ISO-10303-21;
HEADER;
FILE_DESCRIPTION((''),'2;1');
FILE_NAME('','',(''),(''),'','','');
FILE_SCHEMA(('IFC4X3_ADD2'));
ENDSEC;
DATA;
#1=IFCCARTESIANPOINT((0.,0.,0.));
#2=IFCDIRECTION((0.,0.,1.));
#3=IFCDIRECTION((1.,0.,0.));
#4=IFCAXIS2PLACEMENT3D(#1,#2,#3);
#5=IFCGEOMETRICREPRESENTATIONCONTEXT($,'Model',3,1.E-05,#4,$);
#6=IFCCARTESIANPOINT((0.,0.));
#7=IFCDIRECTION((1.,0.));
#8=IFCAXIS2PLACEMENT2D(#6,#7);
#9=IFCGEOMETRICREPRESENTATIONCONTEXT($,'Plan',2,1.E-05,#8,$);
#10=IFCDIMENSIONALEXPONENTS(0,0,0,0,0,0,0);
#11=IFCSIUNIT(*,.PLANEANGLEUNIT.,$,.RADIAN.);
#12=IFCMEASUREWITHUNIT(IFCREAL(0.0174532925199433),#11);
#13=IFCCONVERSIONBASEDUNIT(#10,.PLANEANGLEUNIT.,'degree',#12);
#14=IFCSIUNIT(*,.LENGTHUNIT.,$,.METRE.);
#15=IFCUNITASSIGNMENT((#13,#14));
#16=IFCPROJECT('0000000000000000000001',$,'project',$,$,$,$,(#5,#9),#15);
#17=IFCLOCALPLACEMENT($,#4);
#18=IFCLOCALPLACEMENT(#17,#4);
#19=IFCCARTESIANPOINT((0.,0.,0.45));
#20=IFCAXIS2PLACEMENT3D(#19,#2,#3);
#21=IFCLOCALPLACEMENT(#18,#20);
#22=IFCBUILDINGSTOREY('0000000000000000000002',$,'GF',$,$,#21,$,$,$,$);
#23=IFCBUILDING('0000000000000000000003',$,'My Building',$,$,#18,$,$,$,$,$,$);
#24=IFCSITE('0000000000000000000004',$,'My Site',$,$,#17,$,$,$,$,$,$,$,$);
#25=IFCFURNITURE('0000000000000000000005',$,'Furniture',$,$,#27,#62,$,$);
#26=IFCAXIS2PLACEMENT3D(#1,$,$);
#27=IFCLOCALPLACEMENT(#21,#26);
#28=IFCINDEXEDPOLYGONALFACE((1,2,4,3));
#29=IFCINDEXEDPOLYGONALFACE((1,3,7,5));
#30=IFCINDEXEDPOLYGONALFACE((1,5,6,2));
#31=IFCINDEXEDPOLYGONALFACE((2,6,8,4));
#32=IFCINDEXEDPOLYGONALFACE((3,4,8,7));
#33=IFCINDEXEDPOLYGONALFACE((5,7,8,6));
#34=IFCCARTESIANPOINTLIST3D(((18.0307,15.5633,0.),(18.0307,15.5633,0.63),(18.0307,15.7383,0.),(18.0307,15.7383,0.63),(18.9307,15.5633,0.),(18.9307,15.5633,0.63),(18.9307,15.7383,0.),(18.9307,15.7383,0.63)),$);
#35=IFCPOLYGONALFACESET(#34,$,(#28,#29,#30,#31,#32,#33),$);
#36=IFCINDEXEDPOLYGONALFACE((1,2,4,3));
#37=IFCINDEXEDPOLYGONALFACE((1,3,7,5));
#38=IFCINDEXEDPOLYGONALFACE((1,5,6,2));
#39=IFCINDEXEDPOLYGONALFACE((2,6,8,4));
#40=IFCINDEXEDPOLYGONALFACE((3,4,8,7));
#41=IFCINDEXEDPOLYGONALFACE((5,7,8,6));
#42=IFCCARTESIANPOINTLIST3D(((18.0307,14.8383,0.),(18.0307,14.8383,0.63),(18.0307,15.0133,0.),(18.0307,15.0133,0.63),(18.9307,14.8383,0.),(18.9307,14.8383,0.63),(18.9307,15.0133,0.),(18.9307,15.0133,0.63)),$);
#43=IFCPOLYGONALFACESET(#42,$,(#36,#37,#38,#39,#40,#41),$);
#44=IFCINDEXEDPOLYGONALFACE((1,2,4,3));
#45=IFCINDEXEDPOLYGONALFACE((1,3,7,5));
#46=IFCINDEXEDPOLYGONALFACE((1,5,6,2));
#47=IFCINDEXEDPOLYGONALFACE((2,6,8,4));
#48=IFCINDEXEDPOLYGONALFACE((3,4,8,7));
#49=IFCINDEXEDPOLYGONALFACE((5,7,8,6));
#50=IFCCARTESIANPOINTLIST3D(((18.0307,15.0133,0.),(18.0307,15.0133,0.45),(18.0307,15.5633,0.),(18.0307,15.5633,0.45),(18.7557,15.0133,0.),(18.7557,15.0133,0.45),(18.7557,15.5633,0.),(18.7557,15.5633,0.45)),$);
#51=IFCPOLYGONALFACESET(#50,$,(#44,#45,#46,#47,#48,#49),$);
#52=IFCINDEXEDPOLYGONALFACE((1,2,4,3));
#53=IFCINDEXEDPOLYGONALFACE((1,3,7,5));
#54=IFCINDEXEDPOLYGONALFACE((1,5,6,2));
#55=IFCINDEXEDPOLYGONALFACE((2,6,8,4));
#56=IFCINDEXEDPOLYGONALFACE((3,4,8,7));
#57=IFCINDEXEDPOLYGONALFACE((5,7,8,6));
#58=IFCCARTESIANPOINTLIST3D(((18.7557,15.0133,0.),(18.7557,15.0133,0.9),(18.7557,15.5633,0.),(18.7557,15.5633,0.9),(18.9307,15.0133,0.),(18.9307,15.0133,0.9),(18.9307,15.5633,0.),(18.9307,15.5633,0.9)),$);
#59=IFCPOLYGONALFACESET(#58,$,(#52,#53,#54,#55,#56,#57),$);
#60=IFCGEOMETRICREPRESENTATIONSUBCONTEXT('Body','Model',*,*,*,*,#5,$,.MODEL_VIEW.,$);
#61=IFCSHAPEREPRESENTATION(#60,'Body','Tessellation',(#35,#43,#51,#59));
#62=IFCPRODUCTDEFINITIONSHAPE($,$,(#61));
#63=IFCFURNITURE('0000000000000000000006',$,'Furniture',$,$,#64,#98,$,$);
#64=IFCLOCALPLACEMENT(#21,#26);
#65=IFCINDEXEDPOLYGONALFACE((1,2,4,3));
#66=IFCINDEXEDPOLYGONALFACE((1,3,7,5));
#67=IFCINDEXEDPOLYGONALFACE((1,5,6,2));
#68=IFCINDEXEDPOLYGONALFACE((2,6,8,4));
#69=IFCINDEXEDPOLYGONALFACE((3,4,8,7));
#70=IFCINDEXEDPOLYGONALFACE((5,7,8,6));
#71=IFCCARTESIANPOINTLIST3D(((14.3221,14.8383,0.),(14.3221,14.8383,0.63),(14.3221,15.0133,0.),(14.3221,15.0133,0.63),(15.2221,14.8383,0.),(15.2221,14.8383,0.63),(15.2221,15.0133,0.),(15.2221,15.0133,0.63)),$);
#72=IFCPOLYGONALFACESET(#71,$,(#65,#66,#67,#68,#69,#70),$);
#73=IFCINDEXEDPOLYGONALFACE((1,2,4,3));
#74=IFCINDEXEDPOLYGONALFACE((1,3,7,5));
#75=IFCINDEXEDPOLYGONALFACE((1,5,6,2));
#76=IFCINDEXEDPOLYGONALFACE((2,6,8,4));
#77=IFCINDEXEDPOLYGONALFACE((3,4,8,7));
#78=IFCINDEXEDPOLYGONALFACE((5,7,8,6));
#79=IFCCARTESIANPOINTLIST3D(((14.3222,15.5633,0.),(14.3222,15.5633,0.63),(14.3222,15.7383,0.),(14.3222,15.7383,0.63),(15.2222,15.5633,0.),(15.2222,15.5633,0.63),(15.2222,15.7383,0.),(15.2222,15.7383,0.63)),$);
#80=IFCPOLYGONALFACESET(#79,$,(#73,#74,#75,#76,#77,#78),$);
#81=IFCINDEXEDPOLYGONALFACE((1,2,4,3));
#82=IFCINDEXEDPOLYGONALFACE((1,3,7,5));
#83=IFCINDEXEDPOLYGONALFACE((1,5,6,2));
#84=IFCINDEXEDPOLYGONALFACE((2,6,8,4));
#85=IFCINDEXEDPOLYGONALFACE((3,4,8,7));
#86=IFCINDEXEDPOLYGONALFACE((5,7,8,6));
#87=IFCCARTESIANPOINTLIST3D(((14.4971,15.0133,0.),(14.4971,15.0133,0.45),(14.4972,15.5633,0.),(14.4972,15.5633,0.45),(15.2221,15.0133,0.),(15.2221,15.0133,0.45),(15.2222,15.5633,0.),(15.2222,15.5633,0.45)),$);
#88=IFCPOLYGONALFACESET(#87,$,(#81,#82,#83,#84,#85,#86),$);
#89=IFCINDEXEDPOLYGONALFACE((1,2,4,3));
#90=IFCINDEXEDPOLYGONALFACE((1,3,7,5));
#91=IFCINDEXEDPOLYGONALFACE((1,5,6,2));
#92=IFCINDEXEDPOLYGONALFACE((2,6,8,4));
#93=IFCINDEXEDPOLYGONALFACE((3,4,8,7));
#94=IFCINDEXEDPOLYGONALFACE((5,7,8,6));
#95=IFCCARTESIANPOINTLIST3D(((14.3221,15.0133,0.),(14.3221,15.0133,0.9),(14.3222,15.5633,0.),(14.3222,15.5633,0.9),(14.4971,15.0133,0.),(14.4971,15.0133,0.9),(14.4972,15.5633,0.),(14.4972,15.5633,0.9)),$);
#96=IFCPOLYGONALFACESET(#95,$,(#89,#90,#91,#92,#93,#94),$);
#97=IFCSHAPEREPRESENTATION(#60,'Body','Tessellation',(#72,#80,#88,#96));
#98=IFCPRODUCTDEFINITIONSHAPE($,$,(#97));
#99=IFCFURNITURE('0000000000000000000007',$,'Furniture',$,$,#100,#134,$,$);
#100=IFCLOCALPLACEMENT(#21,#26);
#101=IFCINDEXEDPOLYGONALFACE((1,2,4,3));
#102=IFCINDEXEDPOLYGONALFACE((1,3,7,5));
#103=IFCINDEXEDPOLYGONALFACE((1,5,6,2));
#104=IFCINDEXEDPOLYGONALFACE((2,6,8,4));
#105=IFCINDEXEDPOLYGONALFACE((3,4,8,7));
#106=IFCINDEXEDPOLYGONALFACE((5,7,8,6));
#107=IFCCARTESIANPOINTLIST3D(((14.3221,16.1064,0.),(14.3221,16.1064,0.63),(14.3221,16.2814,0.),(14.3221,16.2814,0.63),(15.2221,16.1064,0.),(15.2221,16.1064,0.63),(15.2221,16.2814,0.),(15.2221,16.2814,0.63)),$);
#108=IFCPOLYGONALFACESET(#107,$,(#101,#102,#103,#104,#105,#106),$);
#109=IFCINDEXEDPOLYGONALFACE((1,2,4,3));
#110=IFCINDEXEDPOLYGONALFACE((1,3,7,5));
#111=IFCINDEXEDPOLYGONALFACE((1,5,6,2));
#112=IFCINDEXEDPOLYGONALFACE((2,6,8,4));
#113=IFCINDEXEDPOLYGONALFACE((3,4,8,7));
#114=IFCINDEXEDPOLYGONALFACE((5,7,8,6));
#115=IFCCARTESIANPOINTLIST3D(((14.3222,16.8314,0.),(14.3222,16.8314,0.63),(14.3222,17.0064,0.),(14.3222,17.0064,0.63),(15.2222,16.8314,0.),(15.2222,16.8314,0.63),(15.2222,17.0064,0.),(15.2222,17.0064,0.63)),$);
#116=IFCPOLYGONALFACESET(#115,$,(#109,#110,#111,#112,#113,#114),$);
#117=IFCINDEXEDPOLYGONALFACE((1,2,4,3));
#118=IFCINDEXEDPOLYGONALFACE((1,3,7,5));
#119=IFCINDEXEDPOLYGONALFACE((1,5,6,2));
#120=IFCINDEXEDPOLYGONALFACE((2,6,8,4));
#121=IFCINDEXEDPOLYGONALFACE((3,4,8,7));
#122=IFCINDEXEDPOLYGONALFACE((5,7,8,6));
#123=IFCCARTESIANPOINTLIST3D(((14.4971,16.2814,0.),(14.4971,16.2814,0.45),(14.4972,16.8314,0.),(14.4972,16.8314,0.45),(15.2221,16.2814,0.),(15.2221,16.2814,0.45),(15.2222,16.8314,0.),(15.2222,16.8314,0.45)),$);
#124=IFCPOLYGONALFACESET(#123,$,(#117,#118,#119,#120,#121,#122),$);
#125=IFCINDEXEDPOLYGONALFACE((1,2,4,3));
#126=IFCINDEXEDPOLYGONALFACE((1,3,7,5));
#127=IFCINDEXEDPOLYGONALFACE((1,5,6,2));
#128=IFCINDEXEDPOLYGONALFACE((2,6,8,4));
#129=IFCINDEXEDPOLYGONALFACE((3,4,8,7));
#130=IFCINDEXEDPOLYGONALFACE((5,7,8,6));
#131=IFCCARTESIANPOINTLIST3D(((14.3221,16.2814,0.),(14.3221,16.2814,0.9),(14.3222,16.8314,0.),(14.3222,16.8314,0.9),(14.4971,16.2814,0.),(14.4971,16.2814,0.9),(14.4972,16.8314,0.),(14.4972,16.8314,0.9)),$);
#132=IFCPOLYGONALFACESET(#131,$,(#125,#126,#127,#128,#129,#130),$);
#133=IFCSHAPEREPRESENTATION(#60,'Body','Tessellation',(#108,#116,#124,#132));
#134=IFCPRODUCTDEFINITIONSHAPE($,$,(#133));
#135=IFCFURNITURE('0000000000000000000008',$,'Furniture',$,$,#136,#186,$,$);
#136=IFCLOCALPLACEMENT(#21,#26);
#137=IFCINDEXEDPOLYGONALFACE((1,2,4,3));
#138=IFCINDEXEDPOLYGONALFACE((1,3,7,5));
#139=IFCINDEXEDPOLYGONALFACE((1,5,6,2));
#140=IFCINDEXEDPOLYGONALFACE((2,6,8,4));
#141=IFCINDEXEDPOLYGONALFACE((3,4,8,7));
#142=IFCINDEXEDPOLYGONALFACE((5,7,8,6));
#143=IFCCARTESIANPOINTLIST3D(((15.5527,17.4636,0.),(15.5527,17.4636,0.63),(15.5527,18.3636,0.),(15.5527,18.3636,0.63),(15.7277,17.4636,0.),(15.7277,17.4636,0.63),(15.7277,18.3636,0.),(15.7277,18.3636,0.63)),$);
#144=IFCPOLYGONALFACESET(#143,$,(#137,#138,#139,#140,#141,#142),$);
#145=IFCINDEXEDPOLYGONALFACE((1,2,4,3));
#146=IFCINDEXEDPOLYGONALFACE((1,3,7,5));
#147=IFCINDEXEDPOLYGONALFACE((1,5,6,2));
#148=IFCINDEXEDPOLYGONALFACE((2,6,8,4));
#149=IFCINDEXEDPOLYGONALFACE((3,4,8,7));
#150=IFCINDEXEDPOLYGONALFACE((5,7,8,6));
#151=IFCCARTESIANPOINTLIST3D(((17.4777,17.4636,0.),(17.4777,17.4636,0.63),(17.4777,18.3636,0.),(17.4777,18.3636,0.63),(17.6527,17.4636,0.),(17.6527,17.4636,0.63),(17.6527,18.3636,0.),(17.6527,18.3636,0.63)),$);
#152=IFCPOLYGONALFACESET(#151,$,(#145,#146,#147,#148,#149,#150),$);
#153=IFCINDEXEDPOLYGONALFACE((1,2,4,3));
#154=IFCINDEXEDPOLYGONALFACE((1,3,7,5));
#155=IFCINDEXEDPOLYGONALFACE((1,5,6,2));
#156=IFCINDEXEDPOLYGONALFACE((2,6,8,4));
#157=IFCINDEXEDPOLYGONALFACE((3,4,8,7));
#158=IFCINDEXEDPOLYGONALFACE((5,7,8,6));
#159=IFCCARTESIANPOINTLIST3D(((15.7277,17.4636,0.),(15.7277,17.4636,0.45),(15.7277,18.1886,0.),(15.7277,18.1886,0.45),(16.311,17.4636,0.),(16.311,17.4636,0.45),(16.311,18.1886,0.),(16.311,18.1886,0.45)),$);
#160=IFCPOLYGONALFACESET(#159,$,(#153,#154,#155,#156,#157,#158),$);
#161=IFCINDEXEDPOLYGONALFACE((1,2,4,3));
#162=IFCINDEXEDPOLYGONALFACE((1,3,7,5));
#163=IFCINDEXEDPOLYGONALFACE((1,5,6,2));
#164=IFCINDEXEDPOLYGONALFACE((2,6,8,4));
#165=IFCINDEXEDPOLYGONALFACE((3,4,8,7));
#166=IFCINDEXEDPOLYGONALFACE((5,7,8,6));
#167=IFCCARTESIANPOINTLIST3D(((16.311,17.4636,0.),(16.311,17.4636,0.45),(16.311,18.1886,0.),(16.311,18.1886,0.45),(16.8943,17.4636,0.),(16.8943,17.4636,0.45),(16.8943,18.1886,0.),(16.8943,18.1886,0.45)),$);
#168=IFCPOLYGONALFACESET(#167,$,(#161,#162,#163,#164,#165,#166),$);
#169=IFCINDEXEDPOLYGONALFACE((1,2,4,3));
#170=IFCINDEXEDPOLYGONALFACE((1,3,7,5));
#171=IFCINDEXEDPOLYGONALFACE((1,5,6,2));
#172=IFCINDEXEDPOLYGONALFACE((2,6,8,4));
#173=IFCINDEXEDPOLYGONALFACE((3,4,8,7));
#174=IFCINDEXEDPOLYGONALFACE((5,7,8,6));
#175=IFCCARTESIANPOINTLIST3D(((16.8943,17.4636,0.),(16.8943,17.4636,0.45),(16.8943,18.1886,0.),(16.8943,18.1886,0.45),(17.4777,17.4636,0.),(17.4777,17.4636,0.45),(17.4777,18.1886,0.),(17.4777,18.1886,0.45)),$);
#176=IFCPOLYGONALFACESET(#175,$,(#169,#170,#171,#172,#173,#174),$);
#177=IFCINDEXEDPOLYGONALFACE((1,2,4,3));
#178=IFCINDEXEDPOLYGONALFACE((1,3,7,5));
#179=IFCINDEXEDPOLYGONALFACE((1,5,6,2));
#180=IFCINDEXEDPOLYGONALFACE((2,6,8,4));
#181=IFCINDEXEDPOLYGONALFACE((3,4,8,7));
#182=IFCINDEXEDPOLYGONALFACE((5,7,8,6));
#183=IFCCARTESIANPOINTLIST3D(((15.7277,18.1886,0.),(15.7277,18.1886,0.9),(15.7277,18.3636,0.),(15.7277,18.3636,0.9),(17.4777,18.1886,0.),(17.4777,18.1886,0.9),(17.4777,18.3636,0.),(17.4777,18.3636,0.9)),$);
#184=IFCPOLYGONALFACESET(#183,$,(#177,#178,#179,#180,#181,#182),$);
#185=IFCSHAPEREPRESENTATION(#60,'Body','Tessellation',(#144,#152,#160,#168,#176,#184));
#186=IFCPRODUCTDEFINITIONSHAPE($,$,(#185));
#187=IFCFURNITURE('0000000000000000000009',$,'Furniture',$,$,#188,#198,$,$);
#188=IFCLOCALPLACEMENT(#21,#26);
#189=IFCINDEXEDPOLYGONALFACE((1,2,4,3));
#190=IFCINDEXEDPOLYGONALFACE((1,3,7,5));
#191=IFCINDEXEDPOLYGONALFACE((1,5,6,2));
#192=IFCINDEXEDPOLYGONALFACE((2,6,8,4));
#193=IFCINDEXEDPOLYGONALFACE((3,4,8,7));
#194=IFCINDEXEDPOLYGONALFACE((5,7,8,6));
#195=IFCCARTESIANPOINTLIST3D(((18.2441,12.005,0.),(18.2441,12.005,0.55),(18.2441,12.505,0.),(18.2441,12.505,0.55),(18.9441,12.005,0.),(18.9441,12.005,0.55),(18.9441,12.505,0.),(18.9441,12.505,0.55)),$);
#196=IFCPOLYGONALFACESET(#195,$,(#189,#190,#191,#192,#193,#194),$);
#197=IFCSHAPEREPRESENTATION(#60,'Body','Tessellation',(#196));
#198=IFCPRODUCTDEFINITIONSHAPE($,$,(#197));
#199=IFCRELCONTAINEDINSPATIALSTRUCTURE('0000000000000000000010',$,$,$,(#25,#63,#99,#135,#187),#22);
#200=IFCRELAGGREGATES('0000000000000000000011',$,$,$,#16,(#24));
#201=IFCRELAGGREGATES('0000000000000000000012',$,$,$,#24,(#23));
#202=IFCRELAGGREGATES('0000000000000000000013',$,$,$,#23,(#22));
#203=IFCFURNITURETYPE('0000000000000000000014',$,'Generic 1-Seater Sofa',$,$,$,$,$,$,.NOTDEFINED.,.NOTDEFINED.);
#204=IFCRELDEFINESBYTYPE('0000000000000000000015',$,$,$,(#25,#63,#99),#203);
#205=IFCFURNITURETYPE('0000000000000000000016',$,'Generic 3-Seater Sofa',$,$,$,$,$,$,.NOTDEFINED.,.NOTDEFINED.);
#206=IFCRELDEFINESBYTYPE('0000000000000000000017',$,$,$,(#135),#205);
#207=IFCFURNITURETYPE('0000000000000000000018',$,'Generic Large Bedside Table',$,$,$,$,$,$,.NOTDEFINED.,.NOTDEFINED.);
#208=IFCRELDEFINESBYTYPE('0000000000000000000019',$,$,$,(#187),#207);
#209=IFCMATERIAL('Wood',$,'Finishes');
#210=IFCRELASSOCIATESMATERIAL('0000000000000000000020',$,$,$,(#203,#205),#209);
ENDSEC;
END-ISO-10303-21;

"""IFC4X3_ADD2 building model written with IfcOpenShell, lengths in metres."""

from ifc_helpers import new_model, entity, si_unit, converted_unit, frame, origin_with_axes, origin_2d_with_axis, place, context, subcontext, project, spatial, line, indexed_curve, outline, extrude, shape, source, transform, mapped, material, type_object, type_shapes, element, save


model = new_model("IFC4X3_ADD2")

# Units and contexts
model_context = context("Model", 3, precision=1e-05, world=origin_with_axes())
plan_context = context("Plan", 2, precision=1e-05, world=origin_2d_with_axis())
body_context_1 = subcontext(model_context, "Body", "Model", "MODEL_VIEW")
body_context_2 = subcontext(plan_context, "Body", "Plan", "PLAN_VIEW")
ifc_project = project(units=[converted_unit("PLANEANGLEUNIT", "degree", entity("IfcReal", 0.0174532925199433), si_unit("PLANEANGLEUNIT", "RADIAN"), dimensions=[0, 0, 0, 0, 0, 0, 0]), si_unit("LENGTHUNIT", "METRE")], contexts=[model_context, plan_context])

# Site, building, storey
site_placement = place(None, origin_with_axes())
site = spatial("IfcSite", under=ifc_project, at=site_placement, Name="My Site")
building_placement = place(site_placement, origin_with_axes())
building = spatial("IfcBuilding", under=site, at=building_placement, Name="My Building")
storey_placement = place(building_placement, frame((0.0, 0.0, 0.45), z_axis=(0.0, 0.0, 1.0), x_axis=(1.0, 0.0, 0.0)))
storey = spatial("IfcBuildingStorey", under=building, at=storey_placement, Name="GF")

# Furniture
ifc_material_1 = material(Name="Wood", Category="Finishes")
furniture_type_1 = type_object("IfcFurnitureType", Name="Generic 1-Seater Sofa", AssemblyPlace="NOTDEFINED", PredefinedType="NOTDEFINED", material=ifc_material_1)
shared_shape_1 = source(origin_with_axes(), body_context_1, "Body", "SweptSolid", [
    extrude(outline(indexed_curve([(0.0, 0.0), (0.175, 0.0), (0.175, 0.9), (0.0, 0.9)], segments=[line(1, 2, 3, 4, 1)])), frame((-0.45, -0.9, 0.0), z_axis=(0.0, 0.0, 1.0), x_axis=(1.0, 0.0, 0.0)), (0.0, 0.0, 1.0), 0.63),
    extrude(outline(indexed_curve([(0.0, 0.0), (0.175, 0.0), (0.175, 0.9), (0.0, 0.9)], segments=[line(1, 2, 3, 4, 1)])), frame((0.275, -0.9, 0.0), z_axis=(0.0, 0.0, 1.0), x_axis=(1.0, 0.0, 0.0)), (0.0, 0.0, 1.0), 0.63),
    extrude(outline(indexed_curve([(0.175, 0.0), (0.725, 0.0), (0.725, 0.725), (0.175, 0.725)], segments=[line(1, 2, 3, 4, 1)])), frame((-0.45, -0.9, 0.0), z_axis=(0.0, 0.0, 1.0), x_axis=(1.0, 0.0, 0.0)), (0.0, 0.0, 1.0), 0.45),
    extrude(outline(indexed_curve([(0.175, 0.9), (0.175, 0.725), (0.725, 0.725), (0.725, 0.9), (0.175, 0.9)])), frame((-0.45, -0.9, 0.0), z_axis=(0.0, 0.0, 1.0), x_axis=(1.0, 0.0, 0.0)), (0.0, 0.0, 1.0), 0.9),
])
shared_shape_2 = source(origin_with_axes(), body_context_2, "Body", "Annotation2D", [
    entity("IfcGeometricCurveSet", [entity("IfcIndexedPolyCurve", entity("IfcCartesianPointList2D", [[0.275, -0.175], [0.275, -0.9], [0.45, -0.9], [0.45, 0.0], [0.275, 0.0], [0.275, -0.9], [-0.275, -0.9], [-0.275, 0.0], [-0.275, -0.175], [0.275, -0.175], [0.275, 0.0], [-0.275, 0.0], [-0.45, 0.0], [-0.45, -0.9], [-0.275, -0.9], [-0.275, -0.175]]))]),
])
type_shapes(furniture_type_1, [shared_shape_1, shared_shape_2])
for number, where, z_axis, x_axis, name in (
    (1, (18.9307, 15.2883, 0.0), (0.0, 0.0, 1.0), (0.0, -1.0, 0.0), "Furniture"),
    (2, (14.3221, 15.2883, 0.0), (0.0, 0.0, 1.0), (0.000003, 1.0, 0.0), "Furniture"),
    (3, (14.3221, 16.5564, 0.0), (0.0, 0.0, 1.0), (0.000003, 1.0, 0.0), "Furniture"),
):
    element("IfcFurniture", number, at=place(storey_placement, frame(where, z_axis=z_axis, x_axis=x_axis)), inside=storey, type_object=furniture_type_1, Name=name, shapes=[
        shape(body_context_1, "Body", "MappedRepresentation", [mapped(shared_shape_1, transform((0.0, 0.0, 0.0), x_axis=(1.0, 0.0, 0.0), y_axis=(0.0, 1.0, 0.0), z_axis=(0.0, 0.0, 1.0), scale=1.0))]),
        shape(body_context_2, "Body", "MappedRepresentation", [mapped(shared_shape_2, transform((0.0, 0.0, 0.0), x_axis=(1.0, 0.0, 0.0), y_axis=(0.0, 1.0, 0.0), z_axis=(0.0, 0.0, 1.0), scale=1.0))]),
    ])
furniture_type_2 = type_object("IfcFurnitureType", Name="Generic 3-Seater Sofa", AssemblyPlace="NOTDEFINED", PredefinedType="NOTDEFINED", material=ifc_material_1)
shared_shape_3 = source(origin_with_axes(), body_context_1, "Body", "SweptSolid", [
    extrude(outline(indexed_curve([(0.0, 0.0), (0.175, 0.0), (0.175, 0.9), (0.0, 0.9)], segments=[line(1, 2, 3, 4, 1)])), frame((-1.05, -0.9, 0.0), z_axis=(0.0, 0.0, 1.0), x_axis=(1.0, 0.0, 0.0)), (0.0, 0.0, 1.0), 0.63),
    extrude(outline(indexed_curve([(0.0, 0.0), (0.175, 0.0), (0.175, 0.9), (0.0, 0.9)], segments=[line(1, 2, 3, 4, 1)])), frame((0.875, -0.9, 0.0), z_axis=(0.0, 0.0, 1.0), x_axis=(1.0, 0.0, 0.0)), (0.0, 0.0, 1.0), 0.63),
    extrude(outline(indexed_curve([(0.175, 0.0), (0.7583, 0.0), (0.7583, 0.725), (0.175, 0.725)], segments=[line(1, 2, 3, 4, 1)])), frame((-1.05, -0.9, 0.0), z_axis=(0.0, 0.0, 1.0), x_axis=(1.0, 0.0, 0.0)), (0.0, 0.0, 1.0), 0.45),
    extrude(outline(indexed_curve([(0.7583, 0.0), (1.3417, 0.0), (1.3417, 0.725), (0.7583, 0.725)], segments=[line(1, 2, 3, 4, 1)])), frame((-1.05, -0.9, 0.0), z_axis=(0.0, 0.0, 1.0), x_axis=(1.0, 0.0, 0.0)), (0.0, 0.0, 1.0), 0.45),
    extrude(outline(indexed_curve([(1.3417, 0.0), (1.925, 0.0), (1.925, 0.725), (1.3417, 0.725)], segments=[line(1, 2, 3, 4, 1)])), frame((-1.05, -0.9, 0.0), z_axis=(0.0, 0.0, 1.0), x_axis=(1.0, 0.0, 0.0)), (0.0, 0.0, 1.0), 0.45),
    extrude(outline(indexed_curve([(0.175, 0.725), (1.925, 0.725), (1.925, 0.9), (0.175, 0.9)], segments=[line(1, 2, 3, 4, 1)])), frame((-1.05, -0.9, 0.0), z_axis=(0.0, 0.0, 1.0), x_axis=(1.0, 0.0, 0.0)), (0.0, 0.0, 1.0), 0.9),
])
shared_shape_4 = source(origin_with_axes(), body_context_2, "Body", "Curve2D", [
    entity("IfcIndexedPolyCurve", entity("IfcCartesianPointList2D", [[-1.05, -0.9], [-0.875, -0.9], [-0.875, 0.0], [-1.05, 0.0]]), [entity("IfcLineIndex", [1, 2, 3, 4, 1])]),
    entity("IfcIndexedPolyCurve", entity("IfcCartesianPointList2D", [[0.875, -0.9], [1.05, -0.9], [1.05, 0.0], [0.875, 0.0]]), [entity("IfcLineIndex", [1, 2, 3, 4, 1])]),
    entity("IfcIndexedPolyCurve", entity("IfcCartesianPointList2D", [[-0.875, -0.9], [-0.2917, -0.9], [-0.2917, -0.175], [-0.875, -0.175]]), [entity("IfcLineIndex", [1, 2, 3, 4, 1])]),
    entity("IfcIndexedPolyCurve", entity("IfcCartesianPointList2D", [[-0.2917, -0.9], [0.2917, -0.9], [0.2917, -0.175], [-0.2917, -0.175]]), [entity("IfcLineIndex", [1, 2, 3, 4, 1])]),
    entity("IfcIndexedPolyCurve", entity("IfcCartesianPointList2D", [[0.2917, -0.9], [0.875, -0.9], [0.875, -0.175], [0.2917, -0.175]]), [entity("IfcLineIndex", [1, 2, 3, 4, 1])]),
    entity("IfcIndexedPolyCurve", entity("IfcCartesianPointList2D", [[-0.875, -0.175], [0.875, -0.175], [0.875, 0.0], [-0.875, 0.0]]), [entity("IfcLineIndex", [1, 2, 3, 4, 1])]),
])
type_shapes(furniture_type_2, [shared_shape_3, shared_shape_4])
furniture_1_placement = place(storey_placement, frame((16.6027, 18.3636, 0.0), z_axis=(0.0, 0.0, 1.0), x_axis=(1.0, 0.0, 0.0)))
element("IfcFurniture", 4, at=furniture_1_placement, inside=storey, type_object=furniture_type_2, Name="Furniture", shapes=[
    shape(body_context_1, "Body", "MappedRepresentation", [mapped(shared_shape_3, transform((0.0, 0.0, 0.0), x_axis=(1.0, 0.0, 0.0), y_axis=(0.0, 1.0, 0.0), z_axis=(0.0, 0.0, 1.0), scale=1.0))]),
    shape(body_context_2, "Body", "MappedRepresentation", [mapped(shared_shape_4, transform((0.0, 0.0, 0.0), x_axis=(1.0, 0.0, 0.0), y_axis=(0.0, 1.0, 0.0), z_axis=(0.0, 0.0, 1.0), scale=1.0))]),
])
furniture_type_3 = type_object("IfcFurnitureType", Name="Generic Large Bedside Table", AssemblyPlace="NOTDEFINED", PredefinedType="NOTDEFINED")
shared_shape_5 = source(origin_with_axes(), body_context_1, "Body", "SweptSolid", [
    extrude(outline(indexed_curve([(0.0, 0.0), (0.7, 0.0), (0.7, 0.5), (0.0, 0.5)], segments=[line(1, 2, 3, 4, 1)])), frame((-0.35, -0.25, 0.0), z_axis=(0.0, 0.0, 1.0), x_axis=(1.0, 0.0, 0.0)), (0.0, 0.0, 1.0), 0.55),
])
shared_shape_6 = source(origin_with_axes(), body_context_2, "Body", "Curve2D", [
    entity("IfcIndexedPolyCurve", entity("IfcCartesianPointList2D", [[-0.35, -0.25], [0.35, -0.25], [0.35, 0.25], [-0.35, 0.25]]), [entity("IfcLineIndex", [1, 2, 3, 4, 1])]),
])
type_shapes(furniture_type_3, [shared_shape_5, shared_shape_6])
for number, where, z_axis, x_axis, name in (
    (5, (18.5941, 12.255, 0.0), (0.0, 0.0, 1.0), (1.0, 0.0, 0.0), "Furniture"),
):
    element("IfcFurniture", number, at=place(storey_placement, frame(where, z_axis=z_axis, x_axis=x_axis)), inside=storey, type_object=furniture_type_3, Name=name, shapes=[
        shape(body_context_1, "Body", "MappedRepresentation", [mapped(shared_shape_5, transform((0.0, 0.0, 0.0), x_axis=(1.0, 0.0, 0.0), y_axis=(0.0, 1.0, 0.0), z_axis=(0.0, 0.0, 1.0), scale=1.0))]),
        shape(body_context_2, "Body", "MappedRepresentation", [mapped(shared_shape_6, transform((0.0, 0.0, 0.0), x_axis=(1.0, 0.0, 0.0), y_axis=(0.0, 1.0, 0.0), z_axis=(0.0, 0.0, 1.0), scale=1.0))]),
    ])

save(model, "model.ifc")
